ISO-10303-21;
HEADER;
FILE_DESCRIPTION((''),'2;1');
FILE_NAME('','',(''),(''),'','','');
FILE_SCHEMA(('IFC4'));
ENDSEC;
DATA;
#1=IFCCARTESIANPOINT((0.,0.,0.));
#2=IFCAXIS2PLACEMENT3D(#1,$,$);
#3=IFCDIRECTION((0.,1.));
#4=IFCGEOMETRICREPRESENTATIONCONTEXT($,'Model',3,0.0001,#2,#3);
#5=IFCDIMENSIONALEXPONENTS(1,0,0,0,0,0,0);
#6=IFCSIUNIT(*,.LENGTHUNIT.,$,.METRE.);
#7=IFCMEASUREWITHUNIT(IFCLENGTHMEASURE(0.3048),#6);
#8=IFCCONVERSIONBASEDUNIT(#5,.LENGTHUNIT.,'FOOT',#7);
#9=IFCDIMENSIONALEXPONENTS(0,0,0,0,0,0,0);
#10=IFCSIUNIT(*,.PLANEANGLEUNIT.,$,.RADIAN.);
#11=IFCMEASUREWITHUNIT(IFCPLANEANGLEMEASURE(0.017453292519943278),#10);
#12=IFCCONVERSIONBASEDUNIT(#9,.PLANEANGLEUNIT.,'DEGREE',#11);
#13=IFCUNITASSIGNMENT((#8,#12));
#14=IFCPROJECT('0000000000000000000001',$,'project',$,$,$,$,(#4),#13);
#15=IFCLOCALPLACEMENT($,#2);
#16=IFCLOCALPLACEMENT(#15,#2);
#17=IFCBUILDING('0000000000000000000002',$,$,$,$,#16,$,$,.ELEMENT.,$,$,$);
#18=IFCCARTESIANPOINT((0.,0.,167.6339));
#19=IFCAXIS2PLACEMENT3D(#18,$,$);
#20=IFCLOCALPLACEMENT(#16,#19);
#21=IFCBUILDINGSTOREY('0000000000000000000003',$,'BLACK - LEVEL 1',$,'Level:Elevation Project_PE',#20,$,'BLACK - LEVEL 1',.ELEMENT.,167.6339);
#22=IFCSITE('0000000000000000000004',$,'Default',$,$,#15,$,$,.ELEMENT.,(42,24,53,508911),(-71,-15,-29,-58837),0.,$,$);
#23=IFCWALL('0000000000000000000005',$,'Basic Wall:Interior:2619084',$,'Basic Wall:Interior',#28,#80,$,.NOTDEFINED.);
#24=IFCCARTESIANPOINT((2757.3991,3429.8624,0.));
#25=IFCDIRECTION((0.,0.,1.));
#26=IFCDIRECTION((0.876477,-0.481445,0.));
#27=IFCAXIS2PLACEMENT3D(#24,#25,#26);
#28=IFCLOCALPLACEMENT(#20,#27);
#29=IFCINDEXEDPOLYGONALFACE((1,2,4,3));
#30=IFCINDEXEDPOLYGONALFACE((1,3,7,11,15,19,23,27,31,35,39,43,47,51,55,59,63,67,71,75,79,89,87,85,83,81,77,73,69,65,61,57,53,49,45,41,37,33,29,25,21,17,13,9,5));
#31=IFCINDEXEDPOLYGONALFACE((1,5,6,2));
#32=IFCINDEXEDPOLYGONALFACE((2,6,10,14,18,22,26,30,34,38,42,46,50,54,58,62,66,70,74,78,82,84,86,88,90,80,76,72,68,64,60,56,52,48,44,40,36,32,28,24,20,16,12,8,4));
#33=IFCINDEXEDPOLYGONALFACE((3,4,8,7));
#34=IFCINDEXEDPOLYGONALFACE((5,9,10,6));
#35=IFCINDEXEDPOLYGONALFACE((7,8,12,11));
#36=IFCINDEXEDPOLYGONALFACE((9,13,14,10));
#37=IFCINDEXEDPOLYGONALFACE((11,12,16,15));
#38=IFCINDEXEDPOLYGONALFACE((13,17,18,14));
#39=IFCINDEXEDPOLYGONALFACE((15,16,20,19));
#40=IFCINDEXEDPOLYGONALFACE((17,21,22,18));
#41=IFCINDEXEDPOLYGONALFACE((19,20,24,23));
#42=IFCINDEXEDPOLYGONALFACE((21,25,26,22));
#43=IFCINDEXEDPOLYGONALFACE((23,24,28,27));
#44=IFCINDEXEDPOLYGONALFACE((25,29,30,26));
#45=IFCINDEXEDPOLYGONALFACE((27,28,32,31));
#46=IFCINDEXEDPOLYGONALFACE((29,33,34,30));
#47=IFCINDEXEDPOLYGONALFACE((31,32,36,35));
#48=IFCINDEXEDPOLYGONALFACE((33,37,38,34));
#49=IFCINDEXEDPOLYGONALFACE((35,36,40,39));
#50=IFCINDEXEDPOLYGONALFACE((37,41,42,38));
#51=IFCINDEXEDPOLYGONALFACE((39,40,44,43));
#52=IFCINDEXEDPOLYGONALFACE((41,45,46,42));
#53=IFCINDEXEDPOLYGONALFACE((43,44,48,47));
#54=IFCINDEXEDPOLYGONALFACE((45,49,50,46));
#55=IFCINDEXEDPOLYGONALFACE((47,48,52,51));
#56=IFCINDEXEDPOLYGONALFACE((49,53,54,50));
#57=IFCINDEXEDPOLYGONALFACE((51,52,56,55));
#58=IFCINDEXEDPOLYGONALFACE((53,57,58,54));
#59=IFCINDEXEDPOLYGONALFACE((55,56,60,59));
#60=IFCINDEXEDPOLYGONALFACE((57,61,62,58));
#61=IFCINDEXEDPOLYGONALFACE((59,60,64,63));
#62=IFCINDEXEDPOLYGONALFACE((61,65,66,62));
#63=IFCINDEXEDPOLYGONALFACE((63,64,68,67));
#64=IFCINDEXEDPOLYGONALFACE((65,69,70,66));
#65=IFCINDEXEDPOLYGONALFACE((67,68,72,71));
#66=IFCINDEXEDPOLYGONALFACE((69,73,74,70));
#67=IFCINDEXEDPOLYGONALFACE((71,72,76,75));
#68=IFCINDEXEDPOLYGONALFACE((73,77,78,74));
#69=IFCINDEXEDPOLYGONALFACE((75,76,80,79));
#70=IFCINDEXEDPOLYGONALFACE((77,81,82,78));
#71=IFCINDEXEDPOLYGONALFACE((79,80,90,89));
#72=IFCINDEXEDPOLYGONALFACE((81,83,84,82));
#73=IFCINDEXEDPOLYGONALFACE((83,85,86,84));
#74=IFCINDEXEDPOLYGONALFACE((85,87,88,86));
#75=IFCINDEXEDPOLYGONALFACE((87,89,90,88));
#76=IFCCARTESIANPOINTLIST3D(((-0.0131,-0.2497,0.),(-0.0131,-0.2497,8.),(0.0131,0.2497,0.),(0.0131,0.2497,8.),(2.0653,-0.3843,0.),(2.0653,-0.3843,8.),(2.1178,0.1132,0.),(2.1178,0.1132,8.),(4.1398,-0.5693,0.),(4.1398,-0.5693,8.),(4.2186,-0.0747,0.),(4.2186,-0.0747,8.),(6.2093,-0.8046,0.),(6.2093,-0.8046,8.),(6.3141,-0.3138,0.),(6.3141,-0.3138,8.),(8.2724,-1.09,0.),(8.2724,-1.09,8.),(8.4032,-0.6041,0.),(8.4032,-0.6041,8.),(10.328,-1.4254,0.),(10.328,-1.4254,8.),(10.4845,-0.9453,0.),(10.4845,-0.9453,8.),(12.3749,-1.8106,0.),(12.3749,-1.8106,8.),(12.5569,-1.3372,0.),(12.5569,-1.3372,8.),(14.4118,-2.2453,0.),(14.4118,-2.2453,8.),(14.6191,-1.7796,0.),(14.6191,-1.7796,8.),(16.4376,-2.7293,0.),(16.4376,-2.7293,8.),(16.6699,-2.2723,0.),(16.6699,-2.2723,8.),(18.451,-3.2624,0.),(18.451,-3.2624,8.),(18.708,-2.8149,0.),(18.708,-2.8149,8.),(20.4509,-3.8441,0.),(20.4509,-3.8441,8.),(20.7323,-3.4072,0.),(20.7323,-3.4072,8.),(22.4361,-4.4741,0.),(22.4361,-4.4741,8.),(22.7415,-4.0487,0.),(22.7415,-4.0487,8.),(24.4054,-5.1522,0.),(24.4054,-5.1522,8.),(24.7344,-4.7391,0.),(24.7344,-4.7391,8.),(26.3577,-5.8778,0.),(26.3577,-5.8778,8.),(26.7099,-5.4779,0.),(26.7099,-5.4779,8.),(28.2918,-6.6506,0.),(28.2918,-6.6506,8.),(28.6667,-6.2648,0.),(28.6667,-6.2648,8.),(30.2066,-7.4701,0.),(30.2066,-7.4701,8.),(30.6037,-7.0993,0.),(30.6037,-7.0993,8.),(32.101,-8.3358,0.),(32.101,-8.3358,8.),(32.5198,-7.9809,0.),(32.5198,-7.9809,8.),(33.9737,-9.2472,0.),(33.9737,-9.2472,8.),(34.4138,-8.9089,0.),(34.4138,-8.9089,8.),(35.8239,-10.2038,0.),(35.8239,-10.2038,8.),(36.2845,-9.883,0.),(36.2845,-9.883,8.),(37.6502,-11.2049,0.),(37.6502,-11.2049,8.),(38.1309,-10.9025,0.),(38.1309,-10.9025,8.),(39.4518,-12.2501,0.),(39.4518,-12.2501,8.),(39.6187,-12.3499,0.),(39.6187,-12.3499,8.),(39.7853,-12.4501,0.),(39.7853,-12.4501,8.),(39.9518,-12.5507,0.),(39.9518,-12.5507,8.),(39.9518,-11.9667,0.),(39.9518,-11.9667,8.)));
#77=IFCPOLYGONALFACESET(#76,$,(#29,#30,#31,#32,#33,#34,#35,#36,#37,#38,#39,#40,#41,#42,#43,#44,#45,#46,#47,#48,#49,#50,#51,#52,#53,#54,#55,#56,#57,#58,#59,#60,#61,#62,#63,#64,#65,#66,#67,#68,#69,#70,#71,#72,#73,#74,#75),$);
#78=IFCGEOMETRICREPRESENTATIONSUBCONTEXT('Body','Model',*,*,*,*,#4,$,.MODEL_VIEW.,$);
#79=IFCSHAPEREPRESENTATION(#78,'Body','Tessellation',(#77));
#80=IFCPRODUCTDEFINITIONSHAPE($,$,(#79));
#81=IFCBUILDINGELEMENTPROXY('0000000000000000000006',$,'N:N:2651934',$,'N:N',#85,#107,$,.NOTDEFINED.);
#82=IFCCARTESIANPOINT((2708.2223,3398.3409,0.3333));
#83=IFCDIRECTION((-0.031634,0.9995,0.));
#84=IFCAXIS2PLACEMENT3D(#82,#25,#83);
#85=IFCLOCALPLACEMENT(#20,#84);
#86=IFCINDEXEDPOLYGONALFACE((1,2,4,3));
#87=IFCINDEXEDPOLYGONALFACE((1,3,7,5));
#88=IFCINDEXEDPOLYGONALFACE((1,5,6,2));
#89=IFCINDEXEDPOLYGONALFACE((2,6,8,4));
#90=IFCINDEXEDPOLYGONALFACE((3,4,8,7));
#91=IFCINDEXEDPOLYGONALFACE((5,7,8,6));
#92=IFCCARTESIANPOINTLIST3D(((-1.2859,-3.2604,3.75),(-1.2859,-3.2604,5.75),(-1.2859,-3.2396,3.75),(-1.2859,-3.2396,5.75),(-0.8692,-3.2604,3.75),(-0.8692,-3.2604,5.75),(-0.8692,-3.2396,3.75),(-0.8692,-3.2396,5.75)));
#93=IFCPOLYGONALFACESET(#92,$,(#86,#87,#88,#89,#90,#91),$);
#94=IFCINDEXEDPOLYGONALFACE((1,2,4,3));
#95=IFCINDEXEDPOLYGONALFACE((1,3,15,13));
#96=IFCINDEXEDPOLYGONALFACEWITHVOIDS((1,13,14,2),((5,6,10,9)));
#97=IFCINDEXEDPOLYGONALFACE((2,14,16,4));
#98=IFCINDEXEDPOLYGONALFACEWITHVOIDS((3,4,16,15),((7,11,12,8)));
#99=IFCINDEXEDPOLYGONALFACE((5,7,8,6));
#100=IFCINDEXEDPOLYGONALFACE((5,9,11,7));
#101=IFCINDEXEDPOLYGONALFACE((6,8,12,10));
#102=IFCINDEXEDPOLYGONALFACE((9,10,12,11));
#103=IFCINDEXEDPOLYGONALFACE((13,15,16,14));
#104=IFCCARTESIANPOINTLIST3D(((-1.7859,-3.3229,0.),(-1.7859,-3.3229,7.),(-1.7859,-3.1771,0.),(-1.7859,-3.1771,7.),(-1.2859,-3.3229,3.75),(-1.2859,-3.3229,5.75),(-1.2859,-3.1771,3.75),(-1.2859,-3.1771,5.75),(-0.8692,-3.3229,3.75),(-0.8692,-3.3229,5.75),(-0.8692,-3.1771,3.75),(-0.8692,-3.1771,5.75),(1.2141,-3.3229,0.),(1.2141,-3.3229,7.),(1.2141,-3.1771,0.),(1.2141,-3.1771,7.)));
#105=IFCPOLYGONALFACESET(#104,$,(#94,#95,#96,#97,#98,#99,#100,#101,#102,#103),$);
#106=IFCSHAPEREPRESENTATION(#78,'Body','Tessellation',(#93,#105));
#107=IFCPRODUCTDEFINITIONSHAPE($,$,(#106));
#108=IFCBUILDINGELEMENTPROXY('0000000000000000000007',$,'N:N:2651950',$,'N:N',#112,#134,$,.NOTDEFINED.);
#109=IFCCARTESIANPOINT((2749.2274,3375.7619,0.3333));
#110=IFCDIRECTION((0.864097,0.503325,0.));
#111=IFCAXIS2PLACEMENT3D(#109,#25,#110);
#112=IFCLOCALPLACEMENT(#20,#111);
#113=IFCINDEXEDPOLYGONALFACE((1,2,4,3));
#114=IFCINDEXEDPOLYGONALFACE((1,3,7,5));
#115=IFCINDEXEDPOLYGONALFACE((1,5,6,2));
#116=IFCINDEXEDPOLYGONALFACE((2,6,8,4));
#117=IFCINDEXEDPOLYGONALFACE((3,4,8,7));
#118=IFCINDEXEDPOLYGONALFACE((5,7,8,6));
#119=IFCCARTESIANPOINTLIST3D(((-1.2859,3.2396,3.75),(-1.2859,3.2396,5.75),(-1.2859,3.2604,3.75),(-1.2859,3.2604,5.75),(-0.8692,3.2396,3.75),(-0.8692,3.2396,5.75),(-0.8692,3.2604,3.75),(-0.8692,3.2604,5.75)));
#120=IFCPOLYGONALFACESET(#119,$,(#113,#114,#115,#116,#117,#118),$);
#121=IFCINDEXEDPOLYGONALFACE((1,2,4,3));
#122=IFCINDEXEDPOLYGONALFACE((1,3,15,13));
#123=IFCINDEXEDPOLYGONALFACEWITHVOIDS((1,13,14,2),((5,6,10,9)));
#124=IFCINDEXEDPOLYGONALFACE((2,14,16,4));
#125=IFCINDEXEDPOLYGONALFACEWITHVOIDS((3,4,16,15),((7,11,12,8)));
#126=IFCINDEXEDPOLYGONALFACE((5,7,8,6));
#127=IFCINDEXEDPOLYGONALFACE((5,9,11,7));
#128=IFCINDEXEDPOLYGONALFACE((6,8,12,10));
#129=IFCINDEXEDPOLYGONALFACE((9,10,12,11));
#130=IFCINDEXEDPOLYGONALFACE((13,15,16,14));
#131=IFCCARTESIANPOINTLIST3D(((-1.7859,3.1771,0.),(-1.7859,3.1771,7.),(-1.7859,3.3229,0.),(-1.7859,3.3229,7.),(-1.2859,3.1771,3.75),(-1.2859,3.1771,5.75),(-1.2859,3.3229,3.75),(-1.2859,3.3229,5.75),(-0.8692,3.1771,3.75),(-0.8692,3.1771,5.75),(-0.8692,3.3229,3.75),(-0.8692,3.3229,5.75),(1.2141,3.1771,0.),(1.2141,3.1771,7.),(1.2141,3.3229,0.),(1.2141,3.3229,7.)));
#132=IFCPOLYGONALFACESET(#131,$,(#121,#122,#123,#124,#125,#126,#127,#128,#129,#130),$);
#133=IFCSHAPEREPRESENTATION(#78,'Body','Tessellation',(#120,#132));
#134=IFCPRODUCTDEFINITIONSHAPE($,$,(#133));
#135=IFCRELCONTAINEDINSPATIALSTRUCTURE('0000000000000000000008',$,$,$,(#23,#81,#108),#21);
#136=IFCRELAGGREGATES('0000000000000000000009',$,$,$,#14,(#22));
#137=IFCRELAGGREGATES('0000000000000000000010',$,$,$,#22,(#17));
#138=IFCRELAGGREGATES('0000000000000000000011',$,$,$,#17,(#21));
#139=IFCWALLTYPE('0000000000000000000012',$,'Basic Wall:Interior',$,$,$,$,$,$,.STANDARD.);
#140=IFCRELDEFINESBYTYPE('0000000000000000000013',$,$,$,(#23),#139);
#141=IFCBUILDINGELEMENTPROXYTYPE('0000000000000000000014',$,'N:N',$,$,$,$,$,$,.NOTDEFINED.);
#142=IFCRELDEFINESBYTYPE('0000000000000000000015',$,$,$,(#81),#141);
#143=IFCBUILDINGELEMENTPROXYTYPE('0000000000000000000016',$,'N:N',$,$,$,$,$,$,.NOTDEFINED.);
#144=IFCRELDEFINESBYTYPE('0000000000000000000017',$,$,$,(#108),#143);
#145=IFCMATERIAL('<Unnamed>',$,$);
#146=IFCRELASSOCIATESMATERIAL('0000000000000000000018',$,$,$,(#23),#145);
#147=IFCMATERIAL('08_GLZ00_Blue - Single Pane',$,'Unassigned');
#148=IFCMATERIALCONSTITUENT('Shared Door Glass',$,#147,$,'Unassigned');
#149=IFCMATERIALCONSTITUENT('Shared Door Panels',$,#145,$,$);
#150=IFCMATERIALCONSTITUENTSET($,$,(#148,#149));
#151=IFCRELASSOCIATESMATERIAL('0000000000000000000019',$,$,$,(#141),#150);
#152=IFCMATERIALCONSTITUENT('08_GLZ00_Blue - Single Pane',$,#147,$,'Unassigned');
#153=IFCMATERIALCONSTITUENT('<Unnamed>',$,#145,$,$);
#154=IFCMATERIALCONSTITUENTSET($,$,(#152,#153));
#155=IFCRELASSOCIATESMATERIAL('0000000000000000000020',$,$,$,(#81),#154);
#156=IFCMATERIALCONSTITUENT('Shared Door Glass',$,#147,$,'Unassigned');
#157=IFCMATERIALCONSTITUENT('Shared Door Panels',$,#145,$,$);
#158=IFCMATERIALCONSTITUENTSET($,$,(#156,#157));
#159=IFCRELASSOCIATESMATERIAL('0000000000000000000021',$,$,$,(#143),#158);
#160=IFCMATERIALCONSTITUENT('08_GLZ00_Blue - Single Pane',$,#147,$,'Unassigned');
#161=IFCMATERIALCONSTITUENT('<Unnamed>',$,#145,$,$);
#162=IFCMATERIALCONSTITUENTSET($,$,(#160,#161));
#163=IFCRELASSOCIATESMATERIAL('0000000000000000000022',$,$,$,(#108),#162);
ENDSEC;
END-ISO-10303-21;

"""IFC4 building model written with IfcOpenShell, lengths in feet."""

from ifc_helpers import new_model, entity, si_unit, converted_unit, direction, frame, origin, place, context, subcontext, project, spatial, line, arc, indexed_curve, outline, extrude, source, transform, mapped, material, constituent, constituent_set, type_object, type_shapes, element, save


model = new_model("IFC4")

# Units and contexts
model_context = context("Model", 3, precision=0.0001, world=origin(), true_north=direction((0.0, 1.0)))
body_context = subcontext(model_context, "Body", "Model", "MODEL_VIEW")
ifc_project = project(units=[converted_unit("LENGTHUNIT", "FOOT", entity("IfcLengthMeasure", 0.3048), si_unit("LENGTHUNIT", "METRE"), dimensions=[1, 0, 0, 0, 0, 0, 0]), converted_unit("PLANEANGLEUNIT", "DEGREE", entity("IfcPlaneAngleMeasure", 0.017453292519943278), si_unit("PLANEANGLEUNIT", "RADIAN"), dimensions=[0, 0, 0, 0, 0, 0, 0])], contexts=[model_context])

# Site, building, storey
site_placement = place(None, origin())
site = spatial("IfcSite", under=ifc_project, at=site_placement, Name="Default", CompositionType="ELEMENT", RefLatitude=(42, 24, 53, 508911), RefLongitude=(-71, -15, -29, -58837), RefElevation=0.0)
building_placement = place(site_placement, origin())
building = spatial("IfcBuilding", under=site, at=building_placement, CompositionType="ELEMENT")
storey_placement = place(building_placement, frame((0.0, 0.0, 167.6339)))
storey = spatial("IfcBuildingStorey", under=building, at=storey_placement, Name="BLACK - LEVEL 1", ObjectType="Level:Elevation Project_PE", LongName="BLACK - LEVEL 1", CompositionType="ELEMENT", Elevation=167.6339)

# Wall
ifc_material_1 = material(Name="<Unnamed>")
wall_type = type_object("IfcWallType", Name="Basic Wall:Interior", PredefinedType="STANDARD")
wall_1_placement = place(storey_placement, frame((2757.3991, 3429.8624, 0.0), z_axis=(0.0, 0.0, 1.0), x_axis=(0.876477, -0.481445, 0.0)))
element("IfcWall", 1, at=wall_1_placement, inside=storey, type_object=wall_type, material=ifc_material_1, Name="Basic Wall:Interior:2619084", ObjectType="Basic Wall:Interior", PredefinedType="NOTDEFINED", context=body_context, shape_type="SweptSolid", body=[
    extrude(outline(indexed_curve([(39.9518, -11.9667), (20.7323, -3.4072), (0.0131, 0.2497), (-0.0131, -0.2497), (20.4509, -3.8441), (39.4518, -12.2501), (39.702, -12.4), (39.9518, -12.5507)], segments=[arc(1, 2, 3), line(3, 4), arc(4, 5, 6), arc(6, 7, 8), line(8, 1)], self_intersect=False)), origin(), (0.0, 0.0, 1.0), 8.0),
])

# Building element proxies
ifc_material_2 = material(Name="08_GLZ00_Blue - Single Pane", Category="Unassigned")
ifc_constituent_1 = constituent(ifc_material_2, Name="08_GLZ00_Blue - Single Pane", Category="Unassigned")
ifc_constituent_2 = constituent(ifc_material_1, Name="<Unnamed>")
ifc_constituent_set_1 = constituent_set(constituents=[ifc_constituent_1, ifc_constituent_2])
ifc_constituent_3 = constituent(ifc_material_2, Name="Shared Door Glass", Category="Unassigned")
ifc_constituent_4 = constituent(ifc_material_1, Name="Shared Door Panels")
ifc_constituent_set_2 = constituent_set(constituents=[ifc_constituent_3, ifc_constituent_4])
building_element_proxy_type_1 = type_object("IfcBuildingElementProxyType", Name="N:N", PredefinedType="NOTDEFINED", material=ifc_constituent_set_2)
shared_shape_1 = source(origin(), body_context, "Body", "SweptSolid", [
    extrude(outline(indexed_curve([(-0.2083, -0.0104), (0.2083, -0.0104), (0.2083, 0.0104), (-0.2083, 0.0104), (-0.2083, -0.0104)], self_intersect=False)), frame((-1.0775, -3.25, 3.75), z_axis=(0.0, 0.0, 1.0), x_axis=(-1.0, 0.0, 0.0)), (0.0, 0.0, 1.0), 2.0),
    extrude(outline(indexed_curve([(-3.5, -1.5), (3.5, -1.5), (3.5, 1.5), (-3.5, 1.5), (-3.5, -1.5)], self_intersect=False), holes=[indexed_curve([(-2.25, 0.5833), (-2.25, 1.0), (-0.25, 1.0), (-0.25, 0.5833), (-2.25, 0.5833)], self_intersect=False)]), frame((-0.2859, -3.3229, 3.5), z_axis=(0.0, 1.0, 0.0), x_axis=(0.0, 0.0, -1.0)), (0.0, 0.0, 1.0), 0.1458),
])
type_shapes(building_element_proxy_type_1, [shared_shape_1])
proxy_1_placement = place(storey_placement, frame((2708.2223, 3398.3409, 0.3333), z_axis=(0.0, 0.0, 1.0), x_axis=(-0.031634, 0.9995, 0.0)))
element("IfcBuildingElementProxy", 2, at=proxy_1_placement, inside=storey, type_object=building_element_proxy_type_1, material=ifc_constituent_set_1, Name="N:N:2651934", ObjectType="N:N", PredefinedType="NOTDEFINED", context=body_context, shape_type="MappedRepresentation", body=[
    mapped(shared_shape_1, transform((0.0, 0.0, 0.0), scale=1.0)),
])
ifc_constituent_5 = constituent(ifc_material_2, Name="08_GLZ00_Blue - Single Pane", Category="Unassigned")
ifc_constituent_6 = constituent(ifc_material_1, Name="<Unnamed>")
ifc_constituent_set_3 = constituent_set(constituents=[ifc_constituent_5, ifc_constituent_6])
ifc_constituent_7 = constituent(ifc_material_2, Name="Shared Door Glass", Category="Unassigned")
ifc_constituent_8 = constituent(ifc_material_1, Name="Shared Door Panels")
ifc_constituent_set_4 = constituent_set(constituents=[ifc_constituent_7, ifc_constituent_8])
building_element_proxy_type_2 = type_object("IfcBuildingElementProxyType", Name="N:N", PredefinedType="NOTDEFINED", material=ifc_constituent_set_4)
shared_shape_2 = source(origin(), body_context, "Body", "SweptSolid", [
    extrude(outline(indexed_curve([(-0.0104, -0.2083), (0.0104, -0.2083), (0.0104, 0.2083), (-0.0104, 0.2083), (-0.0104, -0.2083)], self_intersect=False)), frame((-1.0775, 3.25, 3.75), z_axis=(0.0, 0.0, 1.0), x_axis=(0.0, 1.0, 0.0)), (0.0, 0.0, 1.0), 2.0),
    extrude(outline(indexed_curve([(-3.5, -1.5), (3.5, -1.5), (3.5, 1.5), (-3.5, 1.5), (-3.5, -1.5)], self_intersect=False), holes=[indexed_curve([(-2.25, 0.5833), (-2.25, 1.0), (-0.25, 1.0), (-0.25, 0.5833), (-2.25, 0.5833)], self_intersect=False)]), frame((-0.2859, 3.1771, 3.5), z_axis=(0.0, 1.0, 0.0), x_axis=(0.0, 0.0, -1.0)), (0.0, 0.0, 1.0), 0.1458),
])
type_shapes(building_element_proxy_type_2, [shared_shape_2])
proxy_2_placement = place(storey_placement, frame((2749.2274, 3375.7619, 0.3333), z_axis=(0.0, 0.0, 1.0), x_axis=(0.864097, 0.503325, 0.0)))
element("IfcBuildingElementProxy", 3, at=proxy_2_placement, inside=storey, type_object=building_element_proxy_type_2, material=ifc_constituent_set_3, Name="N:N:2651950", ObjectType="N:N", PredefinedType="NOTDEFINED", context=body_context, shape_type="MappedRepresentation", body=[
    mapped(shared_shape_2, transform((0.0, 0.0, 0.0), scale=1.0)),
])

save(model, "model.ifc")
